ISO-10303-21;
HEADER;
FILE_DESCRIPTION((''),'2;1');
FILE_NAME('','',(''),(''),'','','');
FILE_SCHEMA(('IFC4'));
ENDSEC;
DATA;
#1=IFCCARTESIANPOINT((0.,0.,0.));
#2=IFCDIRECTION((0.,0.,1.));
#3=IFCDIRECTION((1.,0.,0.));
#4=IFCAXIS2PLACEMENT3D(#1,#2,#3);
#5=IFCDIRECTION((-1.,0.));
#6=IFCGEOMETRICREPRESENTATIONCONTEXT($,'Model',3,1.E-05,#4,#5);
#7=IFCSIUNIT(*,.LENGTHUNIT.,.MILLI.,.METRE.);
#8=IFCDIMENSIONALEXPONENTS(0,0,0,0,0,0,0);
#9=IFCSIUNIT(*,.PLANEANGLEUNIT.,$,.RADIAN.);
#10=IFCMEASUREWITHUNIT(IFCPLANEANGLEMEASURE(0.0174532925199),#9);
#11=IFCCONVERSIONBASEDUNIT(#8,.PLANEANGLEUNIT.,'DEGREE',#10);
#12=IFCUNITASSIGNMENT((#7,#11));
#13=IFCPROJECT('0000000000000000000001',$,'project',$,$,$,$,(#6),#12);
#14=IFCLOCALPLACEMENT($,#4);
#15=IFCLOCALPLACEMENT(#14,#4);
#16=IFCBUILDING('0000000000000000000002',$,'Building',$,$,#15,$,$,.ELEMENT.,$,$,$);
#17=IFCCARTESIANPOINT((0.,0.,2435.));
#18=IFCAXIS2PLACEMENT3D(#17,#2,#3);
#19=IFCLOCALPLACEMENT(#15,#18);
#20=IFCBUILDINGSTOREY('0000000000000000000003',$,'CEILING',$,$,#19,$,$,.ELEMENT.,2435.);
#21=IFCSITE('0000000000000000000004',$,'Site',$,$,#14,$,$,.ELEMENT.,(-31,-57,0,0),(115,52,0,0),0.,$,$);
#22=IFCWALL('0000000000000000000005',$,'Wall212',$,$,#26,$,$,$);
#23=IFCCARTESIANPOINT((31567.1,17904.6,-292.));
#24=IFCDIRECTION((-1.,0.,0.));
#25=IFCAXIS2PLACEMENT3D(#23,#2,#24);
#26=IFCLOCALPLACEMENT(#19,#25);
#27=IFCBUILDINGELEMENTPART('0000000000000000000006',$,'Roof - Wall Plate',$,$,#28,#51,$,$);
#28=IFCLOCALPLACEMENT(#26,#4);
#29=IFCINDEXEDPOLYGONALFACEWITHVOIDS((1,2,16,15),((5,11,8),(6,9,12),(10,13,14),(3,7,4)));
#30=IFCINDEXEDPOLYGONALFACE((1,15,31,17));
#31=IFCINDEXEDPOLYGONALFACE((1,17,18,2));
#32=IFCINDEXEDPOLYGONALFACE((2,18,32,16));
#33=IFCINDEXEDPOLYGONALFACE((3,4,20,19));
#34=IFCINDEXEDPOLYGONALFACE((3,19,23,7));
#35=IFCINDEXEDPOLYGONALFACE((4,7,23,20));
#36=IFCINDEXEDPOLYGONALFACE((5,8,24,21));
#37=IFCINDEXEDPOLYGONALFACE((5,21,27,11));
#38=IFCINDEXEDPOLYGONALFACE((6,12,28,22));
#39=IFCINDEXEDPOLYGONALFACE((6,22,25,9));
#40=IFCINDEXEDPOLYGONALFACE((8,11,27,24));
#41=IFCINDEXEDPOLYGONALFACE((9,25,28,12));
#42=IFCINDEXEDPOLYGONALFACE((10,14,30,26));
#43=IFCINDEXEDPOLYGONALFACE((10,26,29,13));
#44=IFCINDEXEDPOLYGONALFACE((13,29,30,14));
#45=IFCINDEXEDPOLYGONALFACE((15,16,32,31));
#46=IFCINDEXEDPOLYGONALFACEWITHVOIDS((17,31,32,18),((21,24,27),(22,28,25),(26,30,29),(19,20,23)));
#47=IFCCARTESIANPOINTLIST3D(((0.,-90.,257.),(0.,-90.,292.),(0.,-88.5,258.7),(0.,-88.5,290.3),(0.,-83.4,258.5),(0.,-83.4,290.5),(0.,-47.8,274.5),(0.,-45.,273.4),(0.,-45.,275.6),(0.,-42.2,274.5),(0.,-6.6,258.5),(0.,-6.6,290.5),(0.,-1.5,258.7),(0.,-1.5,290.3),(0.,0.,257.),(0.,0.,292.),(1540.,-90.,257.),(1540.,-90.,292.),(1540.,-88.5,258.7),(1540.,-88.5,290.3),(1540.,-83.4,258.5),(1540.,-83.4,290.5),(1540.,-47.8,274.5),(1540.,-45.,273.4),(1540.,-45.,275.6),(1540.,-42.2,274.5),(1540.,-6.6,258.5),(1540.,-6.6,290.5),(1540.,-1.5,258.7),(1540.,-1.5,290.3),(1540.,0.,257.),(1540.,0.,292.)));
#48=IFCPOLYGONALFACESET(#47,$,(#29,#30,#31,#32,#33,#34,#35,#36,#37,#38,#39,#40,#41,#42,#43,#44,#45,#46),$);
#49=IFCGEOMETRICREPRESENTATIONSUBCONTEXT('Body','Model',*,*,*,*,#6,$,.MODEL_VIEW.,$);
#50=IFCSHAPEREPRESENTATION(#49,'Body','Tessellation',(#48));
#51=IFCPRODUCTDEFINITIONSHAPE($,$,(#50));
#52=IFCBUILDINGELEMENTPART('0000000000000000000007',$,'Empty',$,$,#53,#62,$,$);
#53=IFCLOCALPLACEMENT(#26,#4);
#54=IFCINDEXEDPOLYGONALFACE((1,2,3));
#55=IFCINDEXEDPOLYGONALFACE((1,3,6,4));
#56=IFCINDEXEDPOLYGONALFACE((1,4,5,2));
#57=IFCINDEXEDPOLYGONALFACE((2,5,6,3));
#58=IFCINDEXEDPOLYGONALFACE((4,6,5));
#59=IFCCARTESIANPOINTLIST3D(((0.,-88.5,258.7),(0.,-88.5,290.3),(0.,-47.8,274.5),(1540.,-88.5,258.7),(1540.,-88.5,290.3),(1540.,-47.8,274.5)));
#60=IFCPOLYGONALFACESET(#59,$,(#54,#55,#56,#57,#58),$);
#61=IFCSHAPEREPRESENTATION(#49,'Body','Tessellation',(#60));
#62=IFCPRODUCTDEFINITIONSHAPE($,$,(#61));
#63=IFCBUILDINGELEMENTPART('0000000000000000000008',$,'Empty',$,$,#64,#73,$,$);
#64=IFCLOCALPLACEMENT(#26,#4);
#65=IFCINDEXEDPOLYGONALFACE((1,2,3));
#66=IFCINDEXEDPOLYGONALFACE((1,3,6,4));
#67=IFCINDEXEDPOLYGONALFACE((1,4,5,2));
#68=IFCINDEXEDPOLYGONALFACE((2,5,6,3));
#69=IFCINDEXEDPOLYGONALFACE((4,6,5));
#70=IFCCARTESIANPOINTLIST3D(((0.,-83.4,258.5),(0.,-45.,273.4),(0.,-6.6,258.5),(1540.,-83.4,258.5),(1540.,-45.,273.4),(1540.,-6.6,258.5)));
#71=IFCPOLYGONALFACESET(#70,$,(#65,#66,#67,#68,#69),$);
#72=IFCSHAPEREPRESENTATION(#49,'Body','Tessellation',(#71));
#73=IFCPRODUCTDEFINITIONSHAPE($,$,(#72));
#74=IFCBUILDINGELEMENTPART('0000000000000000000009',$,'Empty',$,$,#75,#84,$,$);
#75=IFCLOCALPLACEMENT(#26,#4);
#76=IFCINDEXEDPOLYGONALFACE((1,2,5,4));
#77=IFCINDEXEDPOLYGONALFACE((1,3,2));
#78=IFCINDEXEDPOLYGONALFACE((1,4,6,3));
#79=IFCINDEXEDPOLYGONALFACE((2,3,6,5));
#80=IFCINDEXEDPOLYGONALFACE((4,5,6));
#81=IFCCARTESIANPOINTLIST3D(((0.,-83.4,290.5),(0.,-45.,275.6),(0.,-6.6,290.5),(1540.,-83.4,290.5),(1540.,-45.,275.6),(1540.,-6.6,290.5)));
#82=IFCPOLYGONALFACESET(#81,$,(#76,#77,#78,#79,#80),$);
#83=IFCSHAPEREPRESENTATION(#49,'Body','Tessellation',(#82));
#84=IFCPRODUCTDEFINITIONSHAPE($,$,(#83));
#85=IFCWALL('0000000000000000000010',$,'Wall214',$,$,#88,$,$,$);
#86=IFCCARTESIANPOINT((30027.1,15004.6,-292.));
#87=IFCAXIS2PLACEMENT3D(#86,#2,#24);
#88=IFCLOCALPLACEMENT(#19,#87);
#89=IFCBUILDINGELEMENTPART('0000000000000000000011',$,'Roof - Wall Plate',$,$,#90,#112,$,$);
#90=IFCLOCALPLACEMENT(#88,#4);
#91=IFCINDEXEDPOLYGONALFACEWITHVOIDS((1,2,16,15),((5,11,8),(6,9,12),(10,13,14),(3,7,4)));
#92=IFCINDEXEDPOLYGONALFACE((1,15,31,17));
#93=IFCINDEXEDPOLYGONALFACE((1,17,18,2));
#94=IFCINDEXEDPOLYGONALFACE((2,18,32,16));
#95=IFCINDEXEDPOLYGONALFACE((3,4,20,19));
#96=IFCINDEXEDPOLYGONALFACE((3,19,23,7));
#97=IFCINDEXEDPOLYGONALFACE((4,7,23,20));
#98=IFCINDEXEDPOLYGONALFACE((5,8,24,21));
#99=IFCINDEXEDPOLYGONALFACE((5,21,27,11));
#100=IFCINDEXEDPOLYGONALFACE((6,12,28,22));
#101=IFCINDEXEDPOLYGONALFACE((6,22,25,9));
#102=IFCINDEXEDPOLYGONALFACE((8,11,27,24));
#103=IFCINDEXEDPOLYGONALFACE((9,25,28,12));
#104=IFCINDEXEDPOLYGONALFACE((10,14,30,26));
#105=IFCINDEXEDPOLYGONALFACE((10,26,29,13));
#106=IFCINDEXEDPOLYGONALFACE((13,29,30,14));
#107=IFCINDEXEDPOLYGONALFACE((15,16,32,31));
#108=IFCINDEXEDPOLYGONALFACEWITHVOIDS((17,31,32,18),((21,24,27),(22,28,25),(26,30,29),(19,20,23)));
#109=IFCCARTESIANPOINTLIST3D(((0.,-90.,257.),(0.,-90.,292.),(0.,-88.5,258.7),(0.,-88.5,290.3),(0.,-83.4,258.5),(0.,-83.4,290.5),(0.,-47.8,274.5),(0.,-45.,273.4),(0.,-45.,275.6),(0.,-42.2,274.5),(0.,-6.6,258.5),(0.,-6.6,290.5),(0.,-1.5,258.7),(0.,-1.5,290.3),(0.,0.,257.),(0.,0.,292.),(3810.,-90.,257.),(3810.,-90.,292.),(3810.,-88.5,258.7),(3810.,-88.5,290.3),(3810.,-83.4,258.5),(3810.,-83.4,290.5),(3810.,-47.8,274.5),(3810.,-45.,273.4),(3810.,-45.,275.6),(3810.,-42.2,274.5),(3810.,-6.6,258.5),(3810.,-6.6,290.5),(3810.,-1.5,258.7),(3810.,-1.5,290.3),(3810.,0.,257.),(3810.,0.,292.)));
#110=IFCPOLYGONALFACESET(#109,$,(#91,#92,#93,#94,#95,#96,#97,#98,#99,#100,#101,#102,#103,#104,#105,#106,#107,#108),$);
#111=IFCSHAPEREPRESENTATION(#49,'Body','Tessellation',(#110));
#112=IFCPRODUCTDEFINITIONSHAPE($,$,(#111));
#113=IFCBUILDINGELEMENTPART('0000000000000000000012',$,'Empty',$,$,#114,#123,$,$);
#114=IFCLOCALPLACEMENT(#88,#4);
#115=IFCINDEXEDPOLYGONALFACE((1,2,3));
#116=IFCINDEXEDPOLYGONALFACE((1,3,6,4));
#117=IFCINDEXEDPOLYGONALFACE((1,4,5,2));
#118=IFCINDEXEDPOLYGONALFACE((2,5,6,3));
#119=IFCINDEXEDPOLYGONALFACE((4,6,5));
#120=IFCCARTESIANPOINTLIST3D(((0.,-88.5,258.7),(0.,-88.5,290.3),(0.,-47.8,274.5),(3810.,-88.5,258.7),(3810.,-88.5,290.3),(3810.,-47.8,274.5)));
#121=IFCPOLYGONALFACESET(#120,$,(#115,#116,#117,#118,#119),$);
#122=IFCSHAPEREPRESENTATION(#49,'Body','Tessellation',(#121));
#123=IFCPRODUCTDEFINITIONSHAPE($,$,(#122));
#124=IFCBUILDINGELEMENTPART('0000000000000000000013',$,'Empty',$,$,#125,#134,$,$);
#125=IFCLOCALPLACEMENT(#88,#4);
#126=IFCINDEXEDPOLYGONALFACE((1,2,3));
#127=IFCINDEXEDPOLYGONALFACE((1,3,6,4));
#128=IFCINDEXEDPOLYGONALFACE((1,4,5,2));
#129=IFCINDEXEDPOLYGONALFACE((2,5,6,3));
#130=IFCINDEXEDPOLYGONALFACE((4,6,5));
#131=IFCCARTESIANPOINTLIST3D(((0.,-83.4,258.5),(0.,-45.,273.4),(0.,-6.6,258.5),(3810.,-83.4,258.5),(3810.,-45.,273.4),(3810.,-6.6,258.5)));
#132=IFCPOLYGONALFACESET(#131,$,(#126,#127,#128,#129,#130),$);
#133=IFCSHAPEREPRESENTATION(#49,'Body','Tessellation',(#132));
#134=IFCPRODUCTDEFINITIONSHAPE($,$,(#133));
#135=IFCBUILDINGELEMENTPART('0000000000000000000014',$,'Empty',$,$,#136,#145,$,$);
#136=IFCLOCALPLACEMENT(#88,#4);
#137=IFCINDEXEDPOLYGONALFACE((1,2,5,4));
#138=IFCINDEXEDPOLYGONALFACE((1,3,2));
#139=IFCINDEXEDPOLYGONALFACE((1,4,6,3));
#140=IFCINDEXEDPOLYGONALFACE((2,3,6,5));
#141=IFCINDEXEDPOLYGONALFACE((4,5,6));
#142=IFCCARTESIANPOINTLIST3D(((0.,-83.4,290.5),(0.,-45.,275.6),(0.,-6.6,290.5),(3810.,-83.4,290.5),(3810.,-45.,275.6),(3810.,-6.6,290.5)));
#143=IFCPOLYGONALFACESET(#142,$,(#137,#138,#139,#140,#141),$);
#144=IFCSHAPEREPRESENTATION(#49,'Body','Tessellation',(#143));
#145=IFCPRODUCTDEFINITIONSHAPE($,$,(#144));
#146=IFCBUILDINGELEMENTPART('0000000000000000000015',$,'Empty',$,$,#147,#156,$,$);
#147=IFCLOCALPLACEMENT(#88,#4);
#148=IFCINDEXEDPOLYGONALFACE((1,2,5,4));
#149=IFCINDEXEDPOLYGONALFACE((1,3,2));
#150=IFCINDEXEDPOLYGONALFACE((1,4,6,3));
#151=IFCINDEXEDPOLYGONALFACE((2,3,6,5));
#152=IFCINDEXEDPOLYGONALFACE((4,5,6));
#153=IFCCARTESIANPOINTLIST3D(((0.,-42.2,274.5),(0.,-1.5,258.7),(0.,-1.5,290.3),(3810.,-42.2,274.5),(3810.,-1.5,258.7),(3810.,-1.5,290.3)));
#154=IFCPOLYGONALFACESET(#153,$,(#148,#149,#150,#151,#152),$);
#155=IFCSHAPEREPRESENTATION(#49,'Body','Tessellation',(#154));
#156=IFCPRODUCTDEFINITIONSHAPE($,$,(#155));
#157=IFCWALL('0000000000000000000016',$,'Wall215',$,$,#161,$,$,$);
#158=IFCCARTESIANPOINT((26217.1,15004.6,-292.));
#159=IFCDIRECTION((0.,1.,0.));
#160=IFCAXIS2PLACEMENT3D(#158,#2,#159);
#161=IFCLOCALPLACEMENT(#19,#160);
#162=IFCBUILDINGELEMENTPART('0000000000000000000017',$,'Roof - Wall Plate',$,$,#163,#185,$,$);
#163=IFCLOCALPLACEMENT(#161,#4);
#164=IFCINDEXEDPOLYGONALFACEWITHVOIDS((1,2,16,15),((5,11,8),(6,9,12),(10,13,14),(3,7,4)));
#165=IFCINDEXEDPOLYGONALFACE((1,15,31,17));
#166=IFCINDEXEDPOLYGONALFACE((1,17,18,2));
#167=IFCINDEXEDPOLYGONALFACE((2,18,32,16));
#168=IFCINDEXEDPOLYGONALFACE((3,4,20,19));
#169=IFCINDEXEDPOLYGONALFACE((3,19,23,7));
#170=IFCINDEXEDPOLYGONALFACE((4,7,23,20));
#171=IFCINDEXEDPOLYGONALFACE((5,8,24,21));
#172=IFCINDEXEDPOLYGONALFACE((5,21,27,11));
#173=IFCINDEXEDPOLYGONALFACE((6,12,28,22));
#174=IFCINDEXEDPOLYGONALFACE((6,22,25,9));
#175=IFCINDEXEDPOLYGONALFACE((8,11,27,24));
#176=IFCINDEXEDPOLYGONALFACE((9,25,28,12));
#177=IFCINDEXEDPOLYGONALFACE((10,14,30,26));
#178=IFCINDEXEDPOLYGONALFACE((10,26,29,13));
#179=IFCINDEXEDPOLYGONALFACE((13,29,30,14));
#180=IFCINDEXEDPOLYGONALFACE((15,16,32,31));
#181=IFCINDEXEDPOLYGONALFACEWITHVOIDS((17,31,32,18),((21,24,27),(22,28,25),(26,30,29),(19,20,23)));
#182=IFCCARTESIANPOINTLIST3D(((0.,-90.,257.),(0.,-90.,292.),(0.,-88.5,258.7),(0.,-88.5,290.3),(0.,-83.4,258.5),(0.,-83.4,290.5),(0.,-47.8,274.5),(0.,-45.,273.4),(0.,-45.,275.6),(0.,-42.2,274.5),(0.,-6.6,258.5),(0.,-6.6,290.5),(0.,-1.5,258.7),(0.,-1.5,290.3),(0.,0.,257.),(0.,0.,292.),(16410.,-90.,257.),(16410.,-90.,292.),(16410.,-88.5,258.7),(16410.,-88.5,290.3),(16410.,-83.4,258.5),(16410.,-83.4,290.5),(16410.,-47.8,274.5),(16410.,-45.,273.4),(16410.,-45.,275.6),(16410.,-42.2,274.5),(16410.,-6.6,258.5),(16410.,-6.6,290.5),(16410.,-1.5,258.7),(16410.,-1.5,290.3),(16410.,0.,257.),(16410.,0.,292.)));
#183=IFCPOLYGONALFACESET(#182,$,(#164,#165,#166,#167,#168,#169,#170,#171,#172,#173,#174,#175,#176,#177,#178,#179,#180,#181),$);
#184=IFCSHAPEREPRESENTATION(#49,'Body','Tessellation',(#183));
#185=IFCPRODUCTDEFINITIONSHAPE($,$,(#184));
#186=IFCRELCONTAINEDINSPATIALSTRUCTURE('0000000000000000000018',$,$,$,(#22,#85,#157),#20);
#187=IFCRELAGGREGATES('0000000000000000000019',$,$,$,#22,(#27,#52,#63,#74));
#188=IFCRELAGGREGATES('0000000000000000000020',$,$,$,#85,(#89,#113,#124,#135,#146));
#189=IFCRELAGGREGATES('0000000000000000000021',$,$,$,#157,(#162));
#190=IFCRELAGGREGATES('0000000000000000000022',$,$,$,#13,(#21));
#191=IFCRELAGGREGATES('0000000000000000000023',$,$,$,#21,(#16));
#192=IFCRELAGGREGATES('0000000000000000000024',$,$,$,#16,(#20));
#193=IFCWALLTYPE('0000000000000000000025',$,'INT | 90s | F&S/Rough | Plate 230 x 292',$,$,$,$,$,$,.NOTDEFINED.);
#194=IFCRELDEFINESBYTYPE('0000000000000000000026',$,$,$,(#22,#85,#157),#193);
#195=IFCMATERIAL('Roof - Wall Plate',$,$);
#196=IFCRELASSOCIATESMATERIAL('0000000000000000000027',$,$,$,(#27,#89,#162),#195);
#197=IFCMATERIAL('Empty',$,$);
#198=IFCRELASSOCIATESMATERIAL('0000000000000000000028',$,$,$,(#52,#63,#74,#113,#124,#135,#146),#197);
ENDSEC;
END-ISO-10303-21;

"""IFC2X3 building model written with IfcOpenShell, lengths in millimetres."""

from ifc_helpers import new_model, entity, si_unit, converted_unit, direction, frame, origin_with_axes, place, context, subcontext, project, spatial, polyline, outline, extrude, material, type_object, element, aggregate, save


model = new_model("IFC2X3")

# Units and contexts
model_context = context("Model", 3, precision=1e-05, world=origin_with_axes(), true_north=direction((-1.0, 0.0)))
body_context = subcontext(model_context, "Body", "Model", "MODEL_VIEW")
ifc_project = project(units=[si_unit("LENGTHUNIT", "METRE", prefix="MILLI"), converted_unit("PLANEANGLEUNIT", "DEGREE", entity("IfcPlaneAngleMeasure", 0.0174532925199), si_unit("PLANEANGLEUNIT", "RADIAN"), dimensions=[0, 0, 0, 0, 0, 0, 0])], contexts=[model_context])

# Site, building, storey
site_placement = place(None, origin_with_axes())
site = spatial("IfcSite", under=ifc_project, at=site_placement, Name="Site", CompositionType="ELEMENT", RefLatitude=(-31, -57, 0, 0), RefLongitude=(115, 52, 0, 0), RefElevation=0.0)
building_placement = place(site_placement, origin_with_axes())
building = spatial("IfcBuilding", under=site, at=building_placement, Name="Building", CompositionType="ELEMENT")
storey_placement = place(building_placement, frame((0.0, 0.0, 2435.0), z_axis=(0.0, 0.0, 1.0), x_axis=(1.0, 0.0, 0.0)))
storey = spatial("IfcBuildingStorey", under=building, at=storey_placement, Name="CEILING", CompositionType="ELEMENT", Elevation=2435.0)

# Walls, building element parts
wall_type = type_object("IfcWallType", Name="INT | 90s | F&S/Rough | Plate 230 x 292", PredefinedType="NOTDEFINED")
wall_1_placement = place(storey_placement, frame((31567.1, 17904.6, -292.0), z_axis=(0.0, 0.0, 1.0), x_axis=(-1.0, 0.0, 0.0)))
wall_1 = element("IfcWall", 1, at=wall_1_placement, inside=storey, type_object=wall_type, Name="Wall212")
ifc_material_1 = material(Name="Roof - Wall Plate")
building_element_part_1_placement = place(wall_1_placement, origin_with_axes())
building_element_part_1 = element("IfcBuildingElementPart", 2, at=building_element_part_1_placement, material=ifc_material_1, Name="Roof - Wall Plate", context=body_context, shape_type="SweptSolid", body=[
    extrude(outline(polyline([(-90.0, 257.0), (0.0, 257.0), (0.0, 292.0), (-90.0, 292.0), (-90.0, 257.0)]), holes=[polyline([(-83.4, 290.5), (-6.6, 290.5), (-45.0, 275.6), (-83.4, 290.5)]), polyline([(-42.2, 274.5), (-1.5, 290.3), (-1.5, 258.7), (-42.2, 274.5)]), polyline([(-6.6, 258.5), (-83.4, 258.5), (-45.0, 273.4), (-6.6, 258.5)]), polyline([(-88.5, 258.7), (-88.5, 290.3), (-47.8, 274.5), (-88.5, 258.7)])]), frame((0.0, 0.0, 0.0), z_axis=(1.0, 0.0, 0.0), x_axis=(0.0, 1.0, 0.0)), (0.0, 0.0, 1.0), 1540.0),
])
ifc_material_2 = material(Name="Empty")
building_element_part_2_placement = place(wall_1_placement, origin_with_axes())
building_element_part_2 = element("IfcBuildingElementPart", 3, at=building_element_part_2_placement, material=ifc_material_2, Name="Empty", context=body_context, shape_type="SweptSolid", body=[
    extrude(outline(polyline([(-47.8, 274.5), (-88.5, 290.3), (-88.5, 258.7), (-47.8, 274.5)])), frame((0.0, 0.0, 0.0), z_axis=(1.0, 0.0, 0.0), x_axis=(0.0, 1.0, 0.0)), (0.0, 0.0, 1.0), 1540.0),
])
building_element_part_3_placement = place(wall_1_placement, origin_with_axes())
building_element_part_3 = element("IfcBuildingElementPart", 4, at=building_element_part_3_placement, material=ifc_material_2, Name="Empty", context=body_context, shape_type="SweptSolid", body=[
    extrude(outline(polyline([(-6.6, 258.5), (-45.0, 273.4), (-83.4, 258.5), (-6.6, 258.5)])), frame((0.0, 0.0, 0.0), z_axis=(1.0, 0.0, 0.0), x_axis=(0.0, 1.0, 0.0)), (0.0, 0.0, 1.0), 1540.0),
])
building_element_part_4_placement = place(wall_1_placement, origin_with_axes())
building_element_part_4 = element("IfcBuildingElementPart", 5, at=building_element_part_4_placement, material=ifc_material_2, Name="Empty", context=body_context, shape_type="SweptSolid", body=[
    extrude(outline(polyline([(-45.0, 275.6), (-6.6, 290.5), (-83.4, 290.5), (-45.0, 275.6)])), frame((0.0, 0.0, 0.0), z_axis=(1.0, 0.0, 0.0), x_axis=(0.0, 1.0, 0.0)), (0.0, 0.0, 1.0), 1540.0),
])
aggregate(wall_1, [building_element_part_1, building_element_part_2, building_element_part_3, building_element_part_4])
wall_2_placement = place(storey_placement, frame((30027.1, 15004.6, -292.0), z_axis=(0.0, 0.0, 1.0), x_axis=(-1.0, 0.0, 0.0)))
wall_2 = element("IfcWall", 6, at=wall_2_placement, inside=storey, type_object=wall_type, Name="Wall214")
building_element_part_5_placement = place(wall_2_placement, origin_with_axes())
building_element_part_5 = element("IfcBuildingElementPart", 7, at=building_element_part_5_placement, material=ifc_material_1, Name="Roof - Wall Plate", context=body_context, shape_type="SweptSolid", body=[
    extrude(outline(polyline([(-90.0, 257.0), (0.0, 257.0), (0.0, 292.0), (-90.0, 292.0), (-90.0, 257.0)]), holes=[polyline([(-83.4, 290.5), (-6.6, 290.5), (-45.0, 275.6), (-83.4, 290.5)]), polyline([(-42.2, 274.5), (-1.5, 290.3), (-1.5, 258.7), (-42.2, 274.5)]), polyline([(-6.6, 258.5), (-83.4, 258.5), (-45.0, 273.4), (-6.6, 258.5)]), polyline([(-88.5, 258.7), (-88.5, 290.3), (-47.8, 274.5), (-88.5, 258.7)])]), frame((0.0, 0.0, 0.0), z_axis=(1.0, 0.0, 0.0), x_axis=(0.0, 1.0, 0.0)), (0.0, 0.0, 1.0), 3810.0),
])
building_element_part_6_placement = place(wall_2_placement, origin_with_axes())
building_element_part_6 = element("IfcBuildingElementPart", 8, at=building_element_part_6_placement, material=ifc_material_2, Name="Empty", context=body_context, shape_type="SweptSolid", body=[
    extrude(outline(polyline([(-47.8, 274.5), (-88.5, 290.3), (-88.5, 258.7), (-47.8, 274.5)])), frame((0.0, 0.0, 0.0), z_axis=(1.0, 0.0, 0.0), x_axis=(0.0, 1.0, 0.0)), (0.0, 0.0, 1.0), 3810.0),
])
building_element_part_7_placement = place(wall_2_placement, origin_with_axes())
building_element_part_7 = element("IfcBuildingElementPart", 9, at=building_element_part_7_placement, material=ifc_material_2, Name="Empty", context=body_context, shape_type="SweptSolid", body=[
    extrude(outline(polyline([(-6.6, 258.5), (-45.0, 273.4), (-83.4, 258.5), (-6.6, 258.5)])), frame((0.0, 0.0, 0.0), z_axis=(1.0, 0.0, 0.0), x_axis=(0.0, 1.0, 0.0)), (0.0, 0.0, 1.0), 3810.0),
])
building_element_part_8_placement = place(wall_2_placement, origin_with_axes())
building_element_part_8 = element("IfcBuildingElementPart", 10, at=building_element_part_8_placement, material=ifc_material_2, Name="Empty", context=body_context, shape_type="SweptSolid", body=[
    extrude(outline(polyline([(-45.0, 275.6), (-6.6, 290.5), (-83.4, 290.5), (-45.0, 275.6)])), frame((0.0, 0.0, 0.0), z_axis=(1.0, 0.0, 0.0), x_axis=(0.0, 1.0, 0.0)), (0.0, 0.0, 1.0), 3810.0),
])
building_element_part_9_placement = place(wall_2_placement, origin_with_axes())
building_element_part_9 = element("IfcBuildingElementPart", 11, at=building_element_part_9_placement, material=ifc_material_2, Name="Empty", context=body_context, shape_type="SweptSolid", body=[
    extrude(outline(polyline([(-42.2, 274.5), (-1.5, 258.7), (-1.5, 290.3), (-42.2, 274.5)])), frame((0.0, 0.0, 0.0), z_axis=(1.0, 0.0, 0.0), x_axis=(0.0, 1.0, 0.0)), (0.0, 0.0, 1.0), 3810.0),
])
aggregate(wall_2, [building_element_part_5, building_element_part_6, building_element_part_7, building_element_part_8, building_element_part_9])
wall_3_placement = place(storey_placement, frame((26217.1, 15004.6, -292.0), z_axis=(0.0, 0.0, 1.0), x_axis=(0.0, 1.0, 0.0)))
wall_3 = element("IfcWall", 12, at=wall_3_placement, inside=storey, type_object=wall_type, Name="Wall215")
building_element_part_10_placement = place(wall_3_placement, origin_with_axes())
building_element_part_10 = element("IfcBuildingElementPart", 13, at=building_element_part_10_placement, material=ifc_material_1, Name="Roof - Wall Plate", context=body_context, shape_type="SweptSolid", body=[
    extrude(outline(polyline([(-90.0, 257.0), (0.0, 257.0), (0.0, 292.0), (-90.0, 292.0), (-90.0, 257.0)]), holes=[polyline([(-83.4, 290.5), (-6.6, 290.5), (-45.0, 275.6), (-83.4, 290.5)]), polyline([(-42.2, 274.5), (-1.5, 290.3), (-1.5, 258.7), (-42.2, 274.5)]), polyline([(-6.6, 258.5), (-83.4, 258.5), (-45.0, 273.4), (-6.6, 258.5)]), polyline([(-88.5, 258.7), (-88.5, 290.3), (-47.8, 274.5), (-88.5, 258.7)])]), frame((0.0, 0.0, 0.0), z_axis=(1.0, 0.0, 0.0), x_axis=(0.0, 1.0, 0.0)), (0.0, 0.0, 1.0), 16410.0),
])
aggregate(wall_3, [building_element_part_10])

save(model, "model.ifc")
